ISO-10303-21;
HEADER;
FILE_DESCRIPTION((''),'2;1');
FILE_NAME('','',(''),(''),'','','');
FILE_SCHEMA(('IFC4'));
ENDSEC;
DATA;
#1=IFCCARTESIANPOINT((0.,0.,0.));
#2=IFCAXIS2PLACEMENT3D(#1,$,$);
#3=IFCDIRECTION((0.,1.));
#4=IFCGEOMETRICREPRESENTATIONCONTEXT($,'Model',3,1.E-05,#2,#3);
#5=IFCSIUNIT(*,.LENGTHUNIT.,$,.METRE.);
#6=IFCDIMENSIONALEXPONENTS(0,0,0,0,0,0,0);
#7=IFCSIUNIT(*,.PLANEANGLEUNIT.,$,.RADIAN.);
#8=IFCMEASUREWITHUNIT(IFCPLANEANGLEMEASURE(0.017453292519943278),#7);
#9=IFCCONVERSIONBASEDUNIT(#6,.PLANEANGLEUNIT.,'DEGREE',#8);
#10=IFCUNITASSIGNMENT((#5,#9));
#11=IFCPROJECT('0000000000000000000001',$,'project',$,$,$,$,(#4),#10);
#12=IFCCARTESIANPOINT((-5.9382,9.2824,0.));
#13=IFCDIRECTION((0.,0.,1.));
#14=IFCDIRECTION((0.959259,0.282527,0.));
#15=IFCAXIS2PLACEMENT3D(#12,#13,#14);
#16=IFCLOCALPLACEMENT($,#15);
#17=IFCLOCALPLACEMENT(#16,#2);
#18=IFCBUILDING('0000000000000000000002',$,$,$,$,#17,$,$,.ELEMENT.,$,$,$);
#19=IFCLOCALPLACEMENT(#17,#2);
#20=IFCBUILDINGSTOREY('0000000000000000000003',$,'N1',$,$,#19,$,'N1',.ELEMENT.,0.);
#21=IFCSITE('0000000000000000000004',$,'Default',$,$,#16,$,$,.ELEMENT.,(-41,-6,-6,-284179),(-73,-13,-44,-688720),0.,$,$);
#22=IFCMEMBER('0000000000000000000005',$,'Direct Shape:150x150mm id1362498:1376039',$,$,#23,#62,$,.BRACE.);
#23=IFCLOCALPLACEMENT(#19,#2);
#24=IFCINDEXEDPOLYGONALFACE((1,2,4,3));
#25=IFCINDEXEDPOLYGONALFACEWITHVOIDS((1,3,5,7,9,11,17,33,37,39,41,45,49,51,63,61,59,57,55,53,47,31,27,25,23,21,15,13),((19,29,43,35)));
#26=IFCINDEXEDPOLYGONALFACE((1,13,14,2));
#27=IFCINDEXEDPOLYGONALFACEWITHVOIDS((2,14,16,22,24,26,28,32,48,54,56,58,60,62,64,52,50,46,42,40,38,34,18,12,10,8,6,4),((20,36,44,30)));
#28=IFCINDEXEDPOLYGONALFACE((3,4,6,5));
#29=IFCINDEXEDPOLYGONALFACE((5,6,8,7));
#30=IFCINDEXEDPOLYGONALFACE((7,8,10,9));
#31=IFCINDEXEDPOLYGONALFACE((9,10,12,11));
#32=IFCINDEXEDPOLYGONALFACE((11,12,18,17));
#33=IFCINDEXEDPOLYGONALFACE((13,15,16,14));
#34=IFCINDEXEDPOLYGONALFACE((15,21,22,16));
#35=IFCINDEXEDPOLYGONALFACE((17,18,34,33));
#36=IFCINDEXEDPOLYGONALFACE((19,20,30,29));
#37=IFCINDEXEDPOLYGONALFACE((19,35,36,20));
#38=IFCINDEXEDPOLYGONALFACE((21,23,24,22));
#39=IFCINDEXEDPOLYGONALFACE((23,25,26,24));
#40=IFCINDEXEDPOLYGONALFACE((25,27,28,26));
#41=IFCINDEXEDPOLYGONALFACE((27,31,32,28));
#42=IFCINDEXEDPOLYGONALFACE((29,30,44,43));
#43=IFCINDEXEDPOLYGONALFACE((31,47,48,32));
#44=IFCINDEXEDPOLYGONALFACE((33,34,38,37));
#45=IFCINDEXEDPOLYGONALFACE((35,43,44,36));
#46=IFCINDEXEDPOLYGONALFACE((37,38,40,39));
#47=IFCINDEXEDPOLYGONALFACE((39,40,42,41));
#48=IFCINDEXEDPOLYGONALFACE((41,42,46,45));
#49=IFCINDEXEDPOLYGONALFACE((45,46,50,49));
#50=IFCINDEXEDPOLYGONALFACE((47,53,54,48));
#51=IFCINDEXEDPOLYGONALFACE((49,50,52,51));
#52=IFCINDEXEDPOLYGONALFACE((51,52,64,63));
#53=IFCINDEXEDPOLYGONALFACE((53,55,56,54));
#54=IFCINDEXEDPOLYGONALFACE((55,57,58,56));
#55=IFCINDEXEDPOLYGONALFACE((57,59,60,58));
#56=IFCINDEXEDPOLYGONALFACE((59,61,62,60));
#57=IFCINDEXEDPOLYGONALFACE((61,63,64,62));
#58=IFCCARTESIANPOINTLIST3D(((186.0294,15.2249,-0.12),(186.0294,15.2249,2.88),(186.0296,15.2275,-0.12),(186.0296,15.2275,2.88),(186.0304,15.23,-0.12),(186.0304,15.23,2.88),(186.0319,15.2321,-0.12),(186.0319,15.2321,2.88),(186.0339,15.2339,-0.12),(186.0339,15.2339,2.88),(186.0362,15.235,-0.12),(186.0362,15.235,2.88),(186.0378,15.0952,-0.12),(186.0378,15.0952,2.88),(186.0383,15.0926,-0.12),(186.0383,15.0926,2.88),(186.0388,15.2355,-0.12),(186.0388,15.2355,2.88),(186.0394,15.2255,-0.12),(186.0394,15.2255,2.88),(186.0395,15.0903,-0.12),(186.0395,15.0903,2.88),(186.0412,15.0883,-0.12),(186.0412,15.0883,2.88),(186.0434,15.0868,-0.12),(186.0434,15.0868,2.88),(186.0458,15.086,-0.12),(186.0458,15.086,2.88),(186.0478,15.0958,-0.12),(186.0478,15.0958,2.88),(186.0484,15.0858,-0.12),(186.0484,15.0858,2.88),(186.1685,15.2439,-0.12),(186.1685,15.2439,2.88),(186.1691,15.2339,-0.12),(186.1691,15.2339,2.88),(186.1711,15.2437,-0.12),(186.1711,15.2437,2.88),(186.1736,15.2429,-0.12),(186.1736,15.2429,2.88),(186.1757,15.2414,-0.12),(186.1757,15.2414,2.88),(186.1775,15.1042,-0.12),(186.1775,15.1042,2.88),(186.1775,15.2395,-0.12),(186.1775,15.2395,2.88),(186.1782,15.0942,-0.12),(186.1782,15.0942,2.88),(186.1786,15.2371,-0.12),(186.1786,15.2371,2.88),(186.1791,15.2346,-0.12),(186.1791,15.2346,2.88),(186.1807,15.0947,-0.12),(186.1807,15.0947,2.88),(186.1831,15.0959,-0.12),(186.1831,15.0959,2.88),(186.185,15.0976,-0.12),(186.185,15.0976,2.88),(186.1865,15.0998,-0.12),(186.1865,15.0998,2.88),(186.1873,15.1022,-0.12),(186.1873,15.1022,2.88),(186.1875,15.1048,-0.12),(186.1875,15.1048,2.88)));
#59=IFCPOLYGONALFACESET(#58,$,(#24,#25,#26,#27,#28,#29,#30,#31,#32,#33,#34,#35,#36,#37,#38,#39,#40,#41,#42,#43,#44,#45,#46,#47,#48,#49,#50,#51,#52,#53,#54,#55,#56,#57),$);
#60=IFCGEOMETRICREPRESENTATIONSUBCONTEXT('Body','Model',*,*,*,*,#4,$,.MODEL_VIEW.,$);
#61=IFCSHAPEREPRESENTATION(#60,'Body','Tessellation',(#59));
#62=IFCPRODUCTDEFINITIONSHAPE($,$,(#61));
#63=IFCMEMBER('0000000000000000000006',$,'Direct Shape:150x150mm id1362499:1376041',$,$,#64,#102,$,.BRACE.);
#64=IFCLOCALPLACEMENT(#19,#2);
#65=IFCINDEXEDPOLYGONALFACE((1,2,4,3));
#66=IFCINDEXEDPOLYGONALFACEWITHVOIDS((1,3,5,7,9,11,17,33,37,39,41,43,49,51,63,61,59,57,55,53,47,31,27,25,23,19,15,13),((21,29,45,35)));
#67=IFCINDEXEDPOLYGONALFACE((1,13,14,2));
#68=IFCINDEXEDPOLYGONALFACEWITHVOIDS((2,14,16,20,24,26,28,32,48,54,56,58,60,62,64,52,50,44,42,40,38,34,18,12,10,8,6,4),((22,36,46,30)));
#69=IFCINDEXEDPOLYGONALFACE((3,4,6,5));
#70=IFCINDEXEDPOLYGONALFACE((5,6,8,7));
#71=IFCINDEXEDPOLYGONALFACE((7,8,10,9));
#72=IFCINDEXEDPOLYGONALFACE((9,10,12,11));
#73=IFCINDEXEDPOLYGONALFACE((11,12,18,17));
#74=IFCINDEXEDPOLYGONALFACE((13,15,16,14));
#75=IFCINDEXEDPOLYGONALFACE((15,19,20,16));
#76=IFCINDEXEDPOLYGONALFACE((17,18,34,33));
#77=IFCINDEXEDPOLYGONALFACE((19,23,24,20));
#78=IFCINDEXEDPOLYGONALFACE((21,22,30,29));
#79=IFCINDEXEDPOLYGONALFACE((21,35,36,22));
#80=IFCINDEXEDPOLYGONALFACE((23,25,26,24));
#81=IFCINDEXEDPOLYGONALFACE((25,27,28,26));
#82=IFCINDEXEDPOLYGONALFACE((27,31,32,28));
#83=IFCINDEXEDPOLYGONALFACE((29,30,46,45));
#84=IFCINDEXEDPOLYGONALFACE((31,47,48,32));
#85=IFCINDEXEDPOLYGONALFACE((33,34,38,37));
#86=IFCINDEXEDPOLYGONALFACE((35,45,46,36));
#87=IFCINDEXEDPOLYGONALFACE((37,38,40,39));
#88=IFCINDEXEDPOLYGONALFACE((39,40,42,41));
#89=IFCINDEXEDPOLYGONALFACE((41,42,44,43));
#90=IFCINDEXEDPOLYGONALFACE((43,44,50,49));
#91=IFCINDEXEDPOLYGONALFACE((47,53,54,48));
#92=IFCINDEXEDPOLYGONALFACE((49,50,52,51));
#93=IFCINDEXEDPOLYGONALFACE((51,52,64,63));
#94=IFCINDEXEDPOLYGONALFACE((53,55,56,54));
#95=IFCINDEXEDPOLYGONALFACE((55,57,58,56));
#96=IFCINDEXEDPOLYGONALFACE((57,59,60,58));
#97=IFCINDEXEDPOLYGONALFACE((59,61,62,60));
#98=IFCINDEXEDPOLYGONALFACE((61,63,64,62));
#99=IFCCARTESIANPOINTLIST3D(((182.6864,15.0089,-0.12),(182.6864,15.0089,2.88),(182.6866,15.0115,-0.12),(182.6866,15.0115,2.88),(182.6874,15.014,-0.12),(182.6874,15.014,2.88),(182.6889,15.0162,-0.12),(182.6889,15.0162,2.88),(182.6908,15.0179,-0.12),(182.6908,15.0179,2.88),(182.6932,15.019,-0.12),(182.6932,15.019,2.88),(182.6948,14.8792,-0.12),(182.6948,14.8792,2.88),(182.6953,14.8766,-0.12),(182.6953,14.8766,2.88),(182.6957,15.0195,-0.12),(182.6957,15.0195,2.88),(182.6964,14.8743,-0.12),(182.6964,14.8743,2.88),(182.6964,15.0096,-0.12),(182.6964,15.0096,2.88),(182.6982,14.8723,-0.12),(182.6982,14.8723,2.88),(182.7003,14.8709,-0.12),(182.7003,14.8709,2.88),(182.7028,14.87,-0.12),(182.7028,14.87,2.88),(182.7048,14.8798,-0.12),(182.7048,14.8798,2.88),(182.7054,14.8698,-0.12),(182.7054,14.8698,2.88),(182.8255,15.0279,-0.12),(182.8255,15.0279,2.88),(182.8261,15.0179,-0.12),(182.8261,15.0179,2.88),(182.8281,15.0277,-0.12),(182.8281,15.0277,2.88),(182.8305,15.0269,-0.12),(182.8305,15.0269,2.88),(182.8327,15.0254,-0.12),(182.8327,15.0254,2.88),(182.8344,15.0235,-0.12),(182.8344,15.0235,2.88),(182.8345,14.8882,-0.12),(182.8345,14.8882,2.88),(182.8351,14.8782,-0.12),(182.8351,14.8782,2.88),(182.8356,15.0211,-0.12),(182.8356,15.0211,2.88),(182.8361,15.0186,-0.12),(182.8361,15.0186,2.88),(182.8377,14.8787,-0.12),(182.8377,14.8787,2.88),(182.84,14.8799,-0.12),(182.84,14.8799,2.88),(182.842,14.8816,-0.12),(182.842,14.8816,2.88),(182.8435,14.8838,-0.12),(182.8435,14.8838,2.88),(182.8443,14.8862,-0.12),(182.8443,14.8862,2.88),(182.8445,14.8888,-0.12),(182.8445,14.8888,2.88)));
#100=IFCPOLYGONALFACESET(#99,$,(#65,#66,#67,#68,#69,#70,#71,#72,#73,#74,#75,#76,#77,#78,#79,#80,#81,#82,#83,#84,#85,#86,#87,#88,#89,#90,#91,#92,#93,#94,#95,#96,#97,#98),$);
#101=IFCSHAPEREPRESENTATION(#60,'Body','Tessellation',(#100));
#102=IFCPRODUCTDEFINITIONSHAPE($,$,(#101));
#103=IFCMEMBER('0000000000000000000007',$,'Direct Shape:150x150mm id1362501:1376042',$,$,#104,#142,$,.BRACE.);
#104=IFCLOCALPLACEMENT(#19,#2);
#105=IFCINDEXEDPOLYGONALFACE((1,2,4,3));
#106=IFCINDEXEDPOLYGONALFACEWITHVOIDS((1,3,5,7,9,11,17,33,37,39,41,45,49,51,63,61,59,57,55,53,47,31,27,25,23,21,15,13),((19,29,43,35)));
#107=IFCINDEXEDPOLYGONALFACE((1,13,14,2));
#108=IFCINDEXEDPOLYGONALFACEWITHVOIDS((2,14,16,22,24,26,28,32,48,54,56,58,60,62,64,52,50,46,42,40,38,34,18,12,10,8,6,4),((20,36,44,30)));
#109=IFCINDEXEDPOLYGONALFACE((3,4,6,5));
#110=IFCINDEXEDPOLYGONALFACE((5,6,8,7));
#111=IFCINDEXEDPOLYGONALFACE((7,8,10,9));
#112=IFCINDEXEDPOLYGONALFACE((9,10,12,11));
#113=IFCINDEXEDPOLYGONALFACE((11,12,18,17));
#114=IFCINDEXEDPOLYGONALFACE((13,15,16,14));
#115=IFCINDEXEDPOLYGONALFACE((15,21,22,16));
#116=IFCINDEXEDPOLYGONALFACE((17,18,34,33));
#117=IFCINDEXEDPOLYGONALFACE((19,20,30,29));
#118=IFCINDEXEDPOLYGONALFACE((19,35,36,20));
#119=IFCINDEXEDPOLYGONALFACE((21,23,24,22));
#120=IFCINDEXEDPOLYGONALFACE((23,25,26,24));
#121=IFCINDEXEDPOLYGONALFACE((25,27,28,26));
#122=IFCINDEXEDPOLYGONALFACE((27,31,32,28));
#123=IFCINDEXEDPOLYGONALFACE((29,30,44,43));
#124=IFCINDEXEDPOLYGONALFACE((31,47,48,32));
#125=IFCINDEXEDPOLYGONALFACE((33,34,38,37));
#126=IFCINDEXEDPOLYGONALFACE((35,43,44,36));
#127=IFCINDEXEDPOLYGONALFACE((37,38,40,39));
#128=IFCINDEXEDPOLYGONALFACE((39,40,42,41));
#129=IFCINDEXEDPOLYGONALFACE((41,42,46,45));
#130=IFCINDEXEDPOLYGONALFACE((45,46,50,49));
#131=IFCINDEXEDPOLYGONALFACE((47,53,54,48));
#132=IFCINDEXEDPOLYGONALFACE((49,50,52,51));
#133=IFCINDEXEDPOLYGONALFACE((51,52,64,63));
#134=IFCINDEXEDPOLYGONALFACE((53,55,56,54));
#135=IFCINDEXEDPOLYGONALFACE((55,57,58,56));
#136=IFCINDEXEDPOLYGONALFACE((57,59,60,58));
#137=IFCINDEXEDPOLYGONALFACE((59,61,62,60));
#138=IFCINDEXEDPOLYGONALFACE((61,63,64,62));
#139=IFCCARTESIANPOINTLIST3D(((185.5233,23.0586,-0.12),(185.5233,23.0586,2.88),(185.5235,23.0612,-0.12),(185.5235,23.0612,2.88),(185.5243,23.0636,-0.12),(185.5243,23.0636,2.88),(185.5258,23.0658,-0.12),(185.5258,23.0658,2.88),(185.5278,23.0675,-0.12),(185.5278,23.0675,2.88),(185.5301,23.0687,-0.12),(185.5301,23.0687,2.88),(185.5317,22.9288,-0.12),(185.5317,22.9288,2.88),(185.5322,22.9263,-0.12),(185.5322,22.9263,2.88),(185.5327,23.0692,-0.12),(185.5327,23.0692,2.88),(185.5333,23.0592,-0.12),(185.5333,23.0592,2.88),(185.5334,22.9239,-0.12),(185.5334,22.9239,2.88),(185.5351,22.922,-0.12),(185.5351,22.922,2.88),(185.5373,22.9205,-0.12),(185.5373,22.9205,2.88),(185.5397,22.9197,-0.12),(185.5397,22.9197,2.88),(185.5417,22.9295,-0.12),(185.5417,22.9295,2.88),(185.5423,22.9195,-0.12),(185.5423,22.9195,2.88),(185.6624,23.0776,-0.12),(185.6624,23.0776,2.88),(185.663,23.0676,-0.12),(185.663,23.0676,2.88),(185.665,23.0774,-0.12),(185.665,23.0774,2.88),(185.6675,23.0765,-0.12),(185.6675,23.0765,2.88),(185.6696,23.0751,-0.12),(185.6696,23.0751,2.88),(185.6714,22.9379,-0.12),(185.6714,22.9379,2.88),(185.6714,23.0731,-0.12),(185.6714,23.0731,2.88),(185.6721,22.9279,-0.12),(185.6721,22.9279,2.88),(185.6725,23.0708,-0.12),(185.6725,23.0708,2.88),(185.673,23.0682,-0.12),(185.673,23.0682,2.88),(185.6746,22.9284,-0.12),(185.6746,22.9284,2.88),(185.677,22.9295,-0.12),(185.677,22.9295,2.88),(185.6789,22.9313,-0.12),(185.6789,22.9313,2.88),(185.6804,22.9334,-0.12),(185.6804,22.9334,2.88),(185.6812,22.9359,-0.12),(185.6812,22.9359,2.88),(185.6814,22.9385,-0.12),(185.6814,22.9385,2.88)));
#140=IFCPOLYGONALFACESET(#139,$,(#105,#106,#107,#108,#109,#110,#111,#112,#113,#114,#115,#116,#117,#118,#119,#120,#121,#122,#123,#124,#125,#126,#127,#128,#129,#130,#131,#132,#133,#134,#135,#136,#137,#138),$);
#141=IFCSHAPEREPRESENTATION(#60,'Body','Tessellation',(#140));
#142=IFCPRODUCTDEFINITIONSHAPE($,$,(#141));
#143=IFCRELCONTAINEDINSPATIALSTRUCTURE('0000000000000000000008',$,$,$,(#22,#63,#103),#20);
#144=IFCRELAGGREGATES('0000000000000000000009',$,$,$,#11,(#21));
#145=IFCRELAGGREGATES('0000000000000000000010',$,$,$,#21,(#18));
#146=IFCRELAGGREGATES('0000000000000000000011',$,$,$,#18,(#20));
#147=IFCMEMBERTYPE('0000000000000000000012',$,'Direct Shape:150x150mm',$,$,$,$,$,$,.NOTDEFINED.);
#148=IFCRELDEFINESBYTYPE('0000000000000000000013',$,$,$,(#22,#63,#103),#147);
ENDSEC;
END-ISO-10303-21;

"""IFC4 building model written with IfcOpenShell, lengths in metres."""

from ifc_helpers import new_model, entity, si_unit, converted_unit, direction, frame, frame_2d, origin, place, context, subcontext, project, spatial, polyline, circle_curve, parameter, trimmed, segment, composite_curve, outline, extrude, type_object, element, save


model = new_model("IFC4")

# Units and contexts
model_context = context("Model", 3, precision=1e-05, world=origin(), true_north=direction((0.0, 1.0)))
body_context = subcontext(model_context, "Body", "Model", "MODEL_VIEW")
ifc_project = project(units=[si_unit("LENGTHUNIT", "METRE"), converted_unit("PLANEANGLEUNIT", "DEGREE", entity("IfcPlaneAngleMeasure", 0.017453292519943278), si_unit("PLANEANGLEUNIT", "RADIAN"), dimensions=[0, 0, 0, 0, 0, 0, 0])], contexts=[model_context])

# Site, building, storey
site_placement = place(None, frame((-5.9382, 9.2824, 0.0), z_axis=(0.0, 0.0, 1.0), x_axis=(0.959259, 0.282527, 0.0)))
site = spatial("IfcSite", under=ifc_project, at=site_placement, Name="Default", CompositionType="ELEMENT", RefLatitude=(-41, -6, -6, -284179), RefLongitude=(-73, -13, -44, -688720), RefElevation=0.0)
building_placement = place(site_placement, origin())
building = spatial("IfcBuilding", under=site, at=building_placement, CompositionType="ELEMENT")
storey_placement = place(building_placement, origin())
storey = spatial("IfcBuildingStorey", under=building, at=storey_placement, Name="N1", LongName="N1", CompositionType="ELEMENT", Elevation=0.0)

# Members
member_type_1 = type_object("IfcMemberType", Name="Direct Shape:150x150mm", PredefinedType="NOTDEFINED")
member_1_placement = place(storey_placement, origin())
element("IfcMember", 1, at=member_1_placement, inside=storey, type_object=member_type_1, Name="Direct Shape:150x150mm id1362498:1376039", PredefinedType="BRACE", context=body_context, shape_type="SweptSolid", body=[
    extrude(outline(composite_curve([segment(polyline([(-0.065, -0.075), (0.065, -0.075)]), True, "CONTINUOUS"), segment(trimmed(circle_curve(frame_2d((0.065, -0.065), x_axis=(-1.0, 0.0)), 0.01), [parameter(90.0)], [parameter(180.0)], True, "PARAMETER"), True, "CONTINUOUS"), segment(polyline([(0.075, -0.065), (0.075, 0.065)]), True, "CONTINUOUS"), segment(trimmed(circle_curve(frame_2d((0.065, 0.065), x_axis=(-1.0, 0.0)), 0.01), [parameter(180.0)], [parameter(270.0)], True, "PARAMETER"), True, "CONTINUOUS"), segment(polyline([(0.065, 0.075), (-0.065, 0.075)]), True, "CONTINUOUS"), segment(trimmed(circle_curve(frame_2d((-0.065, 0.065), x_axis=(-1.0, 0.0)), 0.01), [parameter(270.0)], [parameter(360.0)], True, "PARAMETER"), True, "CONTINUOUS"), segment(polyline([(-0.075, 0.065), (-0.075, -0.065)]), True, "CONTINUOUS"), segment(trimmed(circle_curve(frame_2d((-0.065, -0.065), x_axis=(-1.0, 0.0)), 0.01), [parameter(360.0)], [parameter(90.0)], True, "PARAMETER"), True, "CONTINUOUS")], self_intersect=False), holes=[polyline([(-0.065, -0.065), (-0.065, 0.065), (0.065, 0.065), (0.065, -0.065), (-0.065, -0.065)])]), frame((186.1085, 15.1649, -0.12), z_axis=(0.0, 0.0, 1.0), x_axis=(-0.99792, -0.064471, 0.0)), (0.0, 0.0, 1.0), 3.0),
])
member_2_placement = place(storey_placement, origin())
element("IfcMember", 2, at=member_2_placement, inside=storey, type_object=member_type_1, Name="Direct Shape:150x150mm id1362499:1376041", PredefinedType="BRACE", context=body_context, shape_type="SweptSolid", body=[
    extrude(outline(composite_curve([segment(polyline([(-0.065, -0.075), (0.065, -0.075)]), True, "CONTINUOUS"), segment(trimmed(circle_curve(frame_2d((0.065, -0.065), x_axis=(-1.0, 0.0)), 0.01), [parameter(90.0)], [parameter(180.0)], True, "PARAMETER"), True, "CONTINUOUS"), segment(polyline([(0.075, -0.065), (0.075, 0.065)]), True, "CONTINUOUS"), segment(trimmed(circle_curve(frame_2d((0.065, 0.065), x_axis=(-1.0, 0.0)), 0.01), [parameter(180.0)], [parameter(270.0)], True, "PARAMETER"), True, "CONTINUOUS"), segment(polyline([(0.065, 0.075), (-0.065, 0.075)]), True, "CONTINUOUS"), segment(trimmed(circle_curve(frame_2d((-0.065, 0.065), x_axis=(-1.0, 0.0)), 0.01), [parameter(270.0)], [parameter(360.0)], True, "PARAMETER"), True, "CONTINUOUS"), segment(polyline([(-0.075, 0.065), (-0.075, -0.065)]), True, "CONTINUOUS"), segment(trimmed(circle_curve(frame_2d((-0.065, -0.065), x_axis=(-1.0, 0.0)), 0.01), [parameter(360.0)], [parameter(90.0)], True, "PARAMETER"), True, "CONTINUOUS")], self_intersect=False), holes=[polyline([(-0.065, -0.065), (-0.065, 0.065), (0.065, 0.065), (0.065, -0.065), (-0.065, -0.065)])]), frame((182.7654, 14.9489, -0.12), z_axis=(0.0, 0.0, 1.0), x_axis=(-0.99792, -0.064471, 0.0)), (0.0, 0.0, 1.0), 3.0),
])
member_3_placement = place(storey_placement, origin())
element("IfcMember", 3, at=member_3_placement, inside=storey, type_object=member_type_1, Name="Direct Shape:150x150mm id1362501:1376042", PredefinedType="BRACE", context=body_context, shape_type="SweptSolid", body=[
    extrude(outline(composite_curve([segment(polyline([(-0.065, -0.075), (0.065, -0.075)]), True, "CONTINUOUS"), segment(trimmed(circle_curve(frame_2d((0.065, -0.065), x_axis=(-1.0, 0.0)), 0.01), [parameter(90.0)], [parameter(180.0)], True, "PARAMETER"), True, "CONTINUOUS"), segment(polyline([(0.075, -0.065), (0.075, 0.065)]), True, "CONTINUOUS"), segment(trimmed(circle_curve(frame_2d((0.065, 0.065), x_axis=(-1.0, 0.0)), 0.01), [parameter(180.0)], [parameter(270.0)], True, "PARAMETER"), True, "CONTINUOUS"), segment(polyline([(0.065, 0.075), (-0.065, 0.075)]), True, "CONTINUOUS"), segment(trimmed(circle_curve(frame_2d((-0.065, 0.065), x_axis=(-1.0, 0.0)), 0.01), [parameter(270.0)], [parameter(360.0)], True, "PARAMETER"), True, "CONTINUOUS"), segment(polyline([(-0.075, 0.065), (-0.075, -0.065)]), True, "CONTINUOUS"), segment(trimmed(circle_curve(frame_2d((-0.065, -0.065), x_axis=(-1.0, 0.0)), 0.01), [parameter(360.0)], [parameter(90.0)], True, "PARAMETER"), True, "CONTINUOUS")], self_intersect=False), holes=[polyline([(-0.065, -0.065), (-0.065, 0.065), (0.065, 0.065), (0.065, -0.065), (-0.065, -0.065)])]), frame((185.6024, 22.9985, -0.12), z_axis=(0.0, 0.0, 1.0), x_axis=(-0.99792, -0.064471, 0.0)), (0.0, 0.0, 1.0), 3.0),
])

save(model, "model.ifc")
